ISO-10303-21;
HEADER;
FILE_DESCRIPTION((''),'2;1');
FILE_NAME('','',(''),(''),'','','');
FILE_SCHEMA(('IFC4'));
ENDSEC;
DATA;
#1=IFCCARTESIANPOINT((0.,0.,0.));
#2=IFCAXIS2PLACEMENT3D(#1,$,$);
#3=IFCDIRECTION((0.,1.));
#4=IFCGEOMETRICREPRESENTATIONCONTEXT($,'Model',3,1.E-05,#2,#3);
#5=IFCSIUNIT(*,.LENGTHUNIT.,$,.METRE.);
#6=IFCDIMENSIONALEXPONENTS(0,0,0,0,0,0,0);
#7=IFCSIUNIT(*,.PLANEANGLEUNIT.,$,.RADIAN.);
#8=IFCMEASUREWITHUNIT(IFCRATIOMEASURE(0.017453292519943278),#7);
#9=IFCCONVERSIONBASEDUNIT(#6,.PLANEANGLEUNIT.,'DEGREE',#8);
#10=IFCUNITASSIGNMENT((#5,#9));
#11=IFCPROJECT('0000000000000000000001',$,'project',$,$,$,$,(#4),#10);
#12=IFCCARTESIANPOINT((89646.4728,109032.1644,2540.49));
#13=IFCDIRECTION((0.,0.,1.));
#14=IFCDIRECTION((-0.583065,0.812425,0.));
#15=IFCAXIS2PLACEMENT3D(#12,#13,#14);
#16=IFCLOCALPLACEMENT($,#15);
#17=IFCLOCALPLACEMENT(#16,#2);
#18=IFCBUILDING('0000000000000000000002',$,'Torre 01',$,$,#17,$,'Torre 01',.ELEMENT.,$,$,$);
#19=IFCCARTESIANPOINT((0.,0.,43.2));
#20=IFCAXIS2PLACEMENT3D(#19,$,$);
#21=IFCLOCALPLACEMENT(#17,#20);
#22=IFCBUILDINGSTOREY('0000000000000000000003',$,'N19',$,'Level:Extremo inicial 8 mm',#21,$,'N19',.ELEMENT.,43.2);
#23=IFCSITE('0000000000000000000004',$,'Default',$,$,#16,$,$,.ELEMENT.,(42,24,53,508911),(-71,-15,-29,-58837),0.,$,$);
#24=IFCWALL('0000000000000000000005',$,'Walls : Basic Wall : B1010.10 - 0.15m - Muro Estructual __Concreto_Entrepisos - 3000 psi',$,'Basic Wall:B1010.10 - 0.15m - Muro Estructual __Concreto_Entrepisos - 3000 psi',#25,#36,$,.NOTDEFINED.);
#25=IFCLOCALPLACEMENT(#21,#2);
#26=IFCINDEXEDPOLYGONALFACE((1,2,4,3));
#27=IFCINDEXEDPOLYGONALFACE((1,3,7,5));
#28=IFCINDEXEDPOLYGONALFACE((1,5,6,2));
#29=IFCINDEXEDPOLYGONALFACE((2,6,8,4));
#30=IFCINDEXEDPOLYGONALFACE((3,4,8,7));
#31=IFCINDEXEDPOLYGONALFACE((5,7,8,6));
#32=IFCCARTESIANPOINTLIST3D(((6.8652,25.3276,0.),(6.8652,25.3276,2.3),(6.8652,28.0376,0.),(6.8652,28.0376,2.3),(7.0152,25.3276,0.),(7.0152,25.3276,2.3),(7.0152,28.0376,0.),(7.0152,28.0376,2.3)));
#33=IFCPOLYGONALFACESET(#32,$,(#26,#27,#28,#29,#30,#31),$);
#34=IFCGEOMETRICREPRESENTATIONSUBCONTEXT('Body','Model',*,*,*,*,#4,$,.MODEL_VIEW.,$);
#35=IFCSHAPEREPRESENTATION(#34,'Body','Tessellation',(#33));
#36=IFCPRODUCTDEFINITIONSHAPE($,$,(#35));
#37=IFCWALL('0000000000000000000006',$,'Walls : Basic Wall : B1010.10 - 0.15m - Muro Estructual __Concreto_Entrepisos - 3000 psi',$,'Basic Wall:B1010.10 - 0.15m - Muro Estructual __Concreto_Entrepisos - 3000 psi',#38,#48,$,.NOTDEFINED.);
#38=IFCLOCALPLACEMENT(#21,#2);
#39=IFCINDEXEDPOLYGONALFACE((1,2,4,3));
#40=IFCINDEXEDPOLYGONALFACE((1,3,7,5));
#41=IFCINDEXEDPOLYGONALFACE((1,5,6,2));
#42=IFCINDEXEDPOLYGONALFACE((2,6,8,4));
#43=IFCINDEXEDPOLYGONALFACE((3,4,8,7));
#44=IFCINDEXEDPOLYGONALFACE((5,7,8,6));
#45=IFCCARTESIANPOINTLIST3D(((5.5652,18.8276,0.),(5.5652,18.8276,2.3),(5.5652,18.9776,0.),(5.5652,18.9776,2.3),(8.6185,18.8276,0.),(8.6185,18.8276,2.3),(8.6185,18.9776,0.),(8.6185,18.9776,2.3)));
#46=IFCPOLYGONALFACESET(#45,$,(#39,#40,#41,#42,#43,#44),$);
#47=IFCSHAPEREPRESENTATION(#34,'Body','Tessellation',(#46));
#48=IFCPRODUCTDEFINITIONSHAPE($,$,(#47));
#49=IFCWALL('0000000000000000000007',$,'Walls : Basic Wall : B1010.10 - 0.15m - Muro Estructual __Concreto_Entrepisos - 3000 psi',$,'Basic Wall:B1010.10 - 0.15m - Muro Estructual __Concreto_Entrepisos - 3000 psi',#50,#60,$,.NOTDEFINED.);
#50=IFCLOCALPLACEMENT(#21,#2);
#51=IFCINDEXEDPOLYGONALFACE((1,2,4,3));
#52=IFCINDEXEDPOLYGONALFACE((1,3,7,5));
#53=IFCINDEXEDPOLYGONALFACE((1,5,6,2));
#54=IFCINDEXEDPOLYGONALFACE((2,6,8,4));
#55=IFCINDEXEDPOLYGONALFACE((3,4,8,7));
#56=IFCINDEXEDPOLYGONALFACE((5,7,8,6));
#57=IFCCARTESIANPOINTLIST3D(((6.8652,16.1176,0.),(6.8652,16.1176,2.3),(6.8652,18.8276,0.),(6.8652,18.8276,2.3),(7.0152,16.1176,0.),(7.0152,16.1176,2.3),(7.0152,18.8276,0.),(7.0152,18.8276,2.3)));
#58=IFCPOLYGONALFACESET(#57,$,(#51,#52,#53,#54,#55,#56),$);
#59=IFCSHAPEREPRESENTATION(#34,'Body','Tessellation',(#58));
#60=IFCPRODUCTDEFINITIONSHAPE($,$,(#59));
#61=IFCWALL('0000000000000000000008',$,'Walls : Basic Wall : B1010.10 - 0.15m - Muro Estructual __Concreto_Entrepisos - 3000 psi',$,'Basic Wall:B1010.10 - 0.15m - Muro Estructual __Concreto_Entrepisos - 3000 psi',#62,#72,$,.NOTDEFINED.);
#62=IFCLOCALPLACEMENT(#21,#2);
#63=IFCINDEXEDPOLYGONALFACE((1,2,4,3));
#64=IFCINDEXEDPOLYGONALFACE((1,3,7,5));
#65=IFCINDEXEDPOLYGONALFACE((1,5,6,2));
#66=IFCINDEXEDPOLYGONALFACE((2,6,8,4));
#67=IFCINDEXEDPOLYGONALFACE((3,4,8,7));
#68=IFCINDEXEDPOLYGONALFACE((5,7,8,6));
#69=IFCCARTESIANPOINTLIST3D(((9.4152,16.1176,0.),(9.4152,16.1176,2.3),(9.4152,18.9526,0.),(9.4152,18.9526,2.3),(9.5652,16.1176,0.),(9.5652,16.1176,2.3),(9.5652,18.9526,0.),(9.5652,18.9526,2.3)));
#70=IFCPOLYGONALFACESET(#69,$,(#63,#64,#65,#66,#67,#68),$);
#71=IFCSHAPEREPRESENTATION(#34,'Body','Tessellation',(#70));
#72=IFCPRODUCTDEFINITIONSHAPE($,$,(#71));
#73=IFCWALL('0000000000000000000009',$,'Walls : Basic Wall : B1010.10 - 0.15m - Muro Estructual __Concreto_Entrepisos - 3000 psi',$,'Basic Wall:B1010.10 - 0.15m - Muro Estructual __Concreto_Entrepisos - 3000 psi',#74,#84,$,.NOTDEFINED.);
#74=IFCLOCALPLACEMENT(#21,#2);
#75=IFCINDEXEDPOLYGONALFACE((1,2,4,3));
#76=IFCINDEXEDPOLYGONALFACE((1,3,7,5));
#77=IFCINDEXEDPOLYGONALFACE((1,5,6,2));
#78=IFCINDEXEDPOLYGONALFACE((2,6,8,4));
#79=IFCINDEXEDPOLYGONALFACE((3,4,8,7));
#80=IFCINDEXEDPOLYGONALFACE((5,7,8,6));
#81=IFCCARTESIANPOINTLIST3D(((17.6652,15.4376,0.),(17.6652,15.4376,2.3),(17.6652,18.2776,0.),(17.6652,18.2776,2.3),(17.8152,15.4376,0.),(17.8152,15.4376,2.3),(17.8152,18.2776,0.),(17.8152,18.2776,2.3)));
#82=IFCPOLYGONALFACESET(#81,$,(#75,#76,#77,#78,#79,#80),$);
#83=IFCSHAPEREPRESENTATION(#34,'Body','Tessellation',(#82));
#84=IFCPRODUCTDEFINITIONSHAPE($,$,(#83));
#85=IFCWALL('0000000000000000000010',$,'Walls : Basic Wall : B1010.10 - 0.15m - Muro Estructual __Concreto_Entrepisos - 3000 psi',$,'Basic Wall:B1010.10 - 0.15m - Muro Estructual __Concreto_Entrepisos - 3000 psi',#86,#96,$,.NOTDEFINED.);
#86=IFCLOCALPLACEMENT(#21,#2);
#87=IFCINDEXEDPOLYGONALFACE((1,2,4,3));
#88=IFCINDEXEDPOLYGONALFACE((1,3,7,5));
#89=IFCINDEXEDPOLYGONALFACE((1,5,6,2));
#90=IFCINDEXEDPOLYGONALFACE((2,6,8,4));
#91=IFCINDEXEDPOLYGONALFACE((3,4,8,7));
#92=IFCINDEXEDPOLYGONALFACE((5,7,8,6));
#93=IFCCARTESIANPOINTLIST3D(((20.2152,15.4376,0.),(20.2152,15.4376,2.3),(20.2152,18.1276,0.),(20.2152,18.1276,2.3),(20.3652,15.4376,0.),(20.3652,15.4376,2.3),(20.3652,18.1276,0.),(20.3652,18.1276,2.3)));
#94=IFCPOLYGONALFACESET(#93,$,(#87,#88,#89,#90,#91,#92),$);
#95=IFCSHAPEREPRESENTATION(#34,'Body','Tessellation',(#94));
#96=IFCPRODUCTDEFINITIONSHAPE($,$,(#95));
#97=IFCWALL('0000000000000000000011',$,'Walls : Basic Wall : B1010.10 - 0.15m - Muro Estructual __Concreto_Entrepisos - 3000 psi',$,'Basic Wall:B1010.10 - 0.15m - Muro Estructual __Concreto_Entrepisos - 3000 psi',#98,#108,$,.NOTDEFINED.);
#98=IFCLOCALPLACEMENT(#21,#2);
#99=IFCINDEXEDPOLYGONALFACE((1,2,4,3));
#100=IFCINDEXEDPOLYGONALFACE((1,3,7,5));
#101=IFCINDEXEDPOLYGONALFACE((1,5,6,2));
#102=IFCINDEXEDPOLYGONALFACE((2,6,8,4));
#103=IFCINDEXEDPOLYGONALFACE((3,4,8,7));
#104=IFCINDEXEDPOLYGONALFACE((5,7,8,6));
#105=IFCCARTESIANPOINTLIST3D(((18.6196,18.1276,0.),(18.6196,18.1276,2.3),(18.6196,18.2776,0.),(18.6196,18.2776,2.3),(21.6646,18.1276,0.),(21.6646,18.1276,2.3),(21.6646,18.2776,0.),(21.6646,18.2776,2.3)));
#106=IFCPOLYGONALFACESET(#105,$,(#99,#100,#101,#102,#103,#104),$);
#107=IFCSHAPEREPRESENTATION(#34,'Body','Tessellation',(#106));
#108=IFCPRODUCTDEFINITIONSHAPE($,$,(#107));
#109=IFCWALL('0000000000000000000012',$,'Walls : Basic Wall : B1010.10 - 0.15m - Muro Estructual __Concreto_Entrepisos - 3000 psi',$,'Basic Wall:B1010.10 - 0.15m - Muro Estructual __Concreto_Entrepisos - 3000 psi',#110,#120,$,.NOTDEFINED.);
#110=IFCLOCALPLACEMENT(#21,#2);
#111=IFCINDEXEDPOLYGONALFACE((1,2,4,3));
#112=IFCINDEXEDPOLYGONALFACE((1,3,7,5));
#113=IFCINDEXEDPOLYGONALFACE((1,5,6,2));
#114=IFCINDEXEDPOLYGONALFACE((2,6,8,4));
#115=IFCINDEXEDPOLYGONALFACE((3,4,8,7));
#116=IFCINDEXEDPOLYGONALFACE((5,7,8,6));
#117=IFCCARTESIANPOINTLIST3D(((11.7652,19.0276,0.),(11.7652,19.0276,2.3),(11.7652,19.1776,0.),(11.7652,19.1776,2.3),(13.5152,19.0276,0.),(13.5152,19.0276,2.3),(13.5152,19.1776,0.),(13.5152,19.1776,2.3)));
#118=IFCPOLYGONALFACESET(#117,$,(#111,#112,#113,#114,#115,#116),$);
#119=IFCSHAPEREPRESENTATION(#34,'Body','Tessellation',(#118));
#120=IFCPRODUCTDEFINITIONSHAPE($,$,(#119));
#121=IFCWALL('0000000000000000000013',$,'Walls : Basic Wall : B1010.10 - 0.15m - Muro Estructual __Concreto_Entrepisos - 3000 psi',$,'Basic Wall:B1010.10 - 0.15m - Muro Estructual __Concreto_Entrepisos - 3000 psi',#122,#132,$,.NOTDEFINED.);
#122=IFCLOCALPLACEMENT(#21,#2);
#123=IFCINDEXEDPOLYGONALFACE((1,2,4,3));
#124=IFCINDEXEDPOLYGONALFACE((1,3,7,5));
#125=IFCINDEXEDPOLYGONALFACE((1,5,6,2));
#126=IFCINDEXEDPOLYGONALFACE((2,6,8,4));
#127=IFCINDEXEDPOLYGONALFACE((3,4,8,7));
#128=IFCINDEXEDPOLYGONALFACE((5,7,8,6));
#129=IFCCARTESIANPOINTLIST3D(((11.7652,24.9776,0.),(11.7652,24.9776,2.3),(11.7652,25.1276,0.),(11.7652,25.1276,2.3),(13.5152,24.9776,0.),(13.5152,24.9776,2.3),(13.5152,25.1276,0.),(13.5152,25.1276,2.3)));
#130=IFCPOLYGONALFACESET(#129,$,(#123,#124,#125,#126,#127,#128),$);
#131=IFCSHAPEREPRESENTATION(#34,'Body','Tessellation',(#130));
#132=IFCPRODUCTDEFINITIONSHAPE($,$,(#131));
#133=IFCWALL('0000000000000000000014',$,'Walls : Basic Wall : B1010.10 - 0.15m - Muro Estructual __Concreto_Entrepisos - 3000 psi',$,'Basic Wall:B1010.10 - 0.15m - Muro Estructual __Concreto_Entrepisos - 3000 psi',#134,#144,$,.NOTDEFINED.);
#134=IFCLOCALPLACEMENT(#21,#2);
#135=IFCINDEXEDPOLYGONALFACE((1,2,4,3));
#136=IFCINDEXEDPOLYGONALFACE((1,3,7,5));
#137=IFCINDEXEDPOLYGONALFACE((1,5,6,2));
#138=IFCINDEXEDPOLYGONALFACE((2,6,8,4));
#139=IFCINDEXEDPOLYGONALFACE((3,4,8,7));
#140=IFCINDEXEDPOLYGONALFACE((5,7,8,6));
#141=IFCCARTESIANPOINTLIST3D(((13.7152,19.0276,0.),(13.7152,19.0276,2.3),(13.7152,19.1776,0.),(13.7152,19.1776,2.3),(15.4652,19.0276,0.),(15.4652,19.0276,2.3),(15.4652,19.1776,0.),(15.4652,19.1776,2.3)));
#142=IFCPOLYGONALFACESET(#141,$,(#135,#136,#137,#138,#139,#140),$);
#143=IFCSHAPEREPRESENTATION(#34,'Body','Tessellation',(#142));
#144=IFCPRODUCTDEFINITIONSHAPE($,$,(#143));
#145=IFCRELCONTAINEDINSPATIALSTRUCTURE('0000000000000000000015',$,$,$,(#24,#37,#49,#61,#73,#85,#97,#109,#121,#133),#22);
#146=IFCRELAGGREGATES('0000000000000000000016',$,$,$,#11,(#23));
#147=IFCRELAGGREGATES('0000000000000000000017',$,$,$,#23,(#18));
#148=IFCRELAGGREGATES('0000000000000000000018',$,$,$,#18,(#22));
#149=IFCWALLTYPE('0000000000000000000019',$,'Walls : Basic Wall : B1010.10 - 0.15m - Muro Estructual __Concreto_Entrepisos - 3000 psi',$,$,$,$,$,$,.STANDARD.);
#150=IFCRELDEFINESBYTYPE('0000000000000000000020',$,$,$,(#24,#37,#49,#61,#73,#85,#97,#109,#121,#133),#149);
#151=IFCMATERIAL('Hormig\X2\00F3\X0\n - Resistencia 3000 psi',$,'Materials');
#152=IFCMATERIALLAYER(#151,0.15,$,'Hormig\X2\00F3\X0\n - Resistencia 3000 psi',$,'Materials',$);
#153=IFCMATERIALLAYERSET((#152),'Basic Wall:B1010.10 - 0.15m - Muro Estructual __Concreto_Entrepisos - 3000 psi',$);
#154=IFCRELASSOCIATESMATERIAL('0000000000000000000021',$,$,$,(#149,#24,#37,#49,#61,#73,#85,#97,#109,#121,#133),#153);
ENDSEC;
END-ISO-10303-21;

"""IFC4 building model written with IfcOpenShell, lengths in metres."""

from ifc_helpers import new_model, entity, si_unit, converted_unit, direction, frame, frame_2d, origin, place, context, subcontext, project, spatial, rectangle, extrude, material, layer, layer_set, layer_usage, type_object, element, save


model = new_model("IFC4")

# Units and contexts
model_context = context("Model", 3, precision=1e-05, world=origin(), true_north=direction((0.0, 1.0)))
body_context = subcontext(model_context, "Body", "Model", "MODEL_VIEW")
ifc_project = project(units=[si_unit("LENGTHUNIT", "METRE"), converted_unit("PLANEANGLEUNIT", "DEGREE", entity("IfcRatioMeasure", 0.017453292519943278), si_unit("PLANEANGLEUNIT", "RADIAN"), dimensions=[0, 0, 0, 0, 0, 0, 0])], contexts=[model_context])

# Site, building, storey
site_placement = place(None, frame((89646.4728, 109032.1644, 2540.49), z_axis=(0.0, 0.0, 1.0), x_axis=(-0.583065, 0.812425, 0.0)))
site = spatial("IfcSite", under=ifc_project, at=site_placement, Name="Default", CompositionType="ELEMENT", RefLatitude=(42, 24, 53, 508911), RefLongitude=(-71, -15, -29, -58837), RefElevation=0.0)
building_placement = place(site_placement, origin())
building = spatial("IfcBuilding", under=site, at=building_placement, Name="Torre 01", LongName="Torre 01", CompositionType="ELEMENT")
storey_placement = place(building_placement, frame((0.0, 0.0, 43.2)))
storey = spatial("IfcBuildingStorey", under=building, at=storey_placement, Name="N19", ObjectType="Level:Extremo inicial 8 mm", LongName="N19", CompositionType="ELEMENT", Elevation=43.2)

# Walls
ifc_material = material(Name="Hormigón - Resistencia 3000 psi", Category="Materials")
ifc_layer_1 = layer(ifc_material, 0.15, Name="Hormigón - Resistencia 3000 psi", Category="Materials")
ifc_layer_set_1 = layer_set([ifc_layer_1], Name="Basic Wall:B1010.10 - 0.15m - Muro Estructual __Concreto_Entrepisos - 3000 psi")
wall_type_1 = type_object("IfcWallType", Name="Walls : Basic Wall : B1010.10 - 0.15m - Muro Estructual __Concreto_Entrepisos - 3000 psi", PredefinedType="STANDARD", material=ifc_layer_set_1)
ifc_layer_usage_1 = layer_usage(ifc_layer_set_1, "AXIS2", "NEGATIVE", 0.075)
wall_1_placement = place(storey_placement, frame((6.9402, 25.3276, 0.0), z_axis=(0.0, 0.0, 1.0), x_axis=(0.0, 1.0, 0.0)))
element("IfcWall", 1, at=wall_1_placement, inside=storey, type_object=wall_type_1, material=ifc_layer_usage_1, Name="Walls : Basic Wall : B1010.10 - 0.15m - Muro Estructual __Concreto_Entrepisos - 3000 psi", ObjectType="Basic Wall:B1010.10 - 0.15m - Muro Estructual __Concreto_Entrepisos - 3000 psi", PredefinedType="NOTDEFINED", context=body_context, shape_type="SweptSolid", body=[
    extrude(rectangle(XDim=2.71, YDim=0.15, at=frame_2d((1.355, 0.0), x_axis=(-1.0, 0.0))), origin(), (0.0, 0.0, 1.0), 2.3),
])
ifc_layer_usage_2 = layer_usage(ifc_layer_set_1, "AXIS2", "POSITIVE", -0.075)
wall_2_placement = place(storey_placement, frame((5.5652, 18.9026, 0.0)))
element("IfcWall", 2, at=wall_2_placement, inside=storey, type_object=wall_type_1, material=ifc_layer_usage_2, Name="Walls : Basic Wall : B1010.10 - 0.15m - Muro Estructual __Concreto_Entrepisos - 3000 psi", ObjectType="Basic Wall:B1010.10 - 0.15m - Muro Estructual __Concreto_Entrepisos - 3000 psi", PredefinedType="NOTDEFINED", context=body_context, shape_type="SweptSolid", body=[
    extrude(rectangle(XDim=3.0533, YDim=0.15, at=frame_2d((1.5267, 0.0), x_axis=(-1.0, 0.0))), origin(), (0.0, 0.0, 1.0), 2.3),
])
ifc_layer_usage_3 = layer_usage(ifc_layer_set_1, "AXIS2", "NEGATIVE", 0.075)
wall_3_placement = place(storey_placement, frame((6.9402, 18.8276, 0.0), z_axis=(0.0, 0.0, 1.0), x_axis=(0.0, -1.0, 0.0)))
element("IfcWall", 3, at=wall_3_placement, inside=storey, type_object=wall_type_1, material=ifc_layer_usage_3, Name="Walls : Basic Wall : B1010.10 - 0.15m - Muro Estructual __Concreto_Entrepisos - 3000 psi", ObjectType="Basic Wall:B1010.10 - 0.15m - Muro Estructual __Concreto_Entrepisos - 3000 psi", PredefinedType="NOTDEFINED", context=body_context, shape_type="SweptSolid", body=[
    extrude(rectangle(XDim=2.71, YDim=0.15, at=frame_2d((1.355, 0.0), x_axis=(-1.0, 0.0))), origin(), (0.0, 0.0, 1.0), 2.3),
])
ifc_layer_usage_4 = layer_usage(ifc_layer_set_1, "AXIS2", "NEGATIVE", 0.075)
wall_4_placement = place(storey_placement, frame((9.4902, 18.9526, 0.0), z_axis=(0.0, 0.0, 1.0), x_axis=(0.0, -1.0, 0.0)))
element("IfcWall", 4, at=wall_4_placement, inside=storey, type_object=wall_type_1, material=ifc_layer_usage_4, Name="Walls : Basic Wall : B1010.10 - 0.15m - Muro Estructual __Concreto_Entrepisos - 3000 psi", ObjectType="Basic Wall:B1010.10 - 0.15m - Muro Estructual __Concreto_Entrepisos - 3000 psi", PredefinedType="NOTDEFINED", context=body_context, shape_type="SweptSolid", body=[
    extrude(rectangle(XDim=2.835, YDim=0.15, at=frame_2d((1.4175, 0.0), x_axis=(-1.0, 0.0))), origin(), (0.0, 0.0, 1.0), 2.3),
])
ifc_layer_usage_5 = layer_usage(ifc_layer_set_1, "AXIS2", "NEGATIVE", 0.075)
wall_5_placement = place(storey_placement, frame((17.7402, 18.2776, 0.0), z_axis=(0.0, 0.0, 1.0), x_axis=(0.0, -1.0, 0.0)))
element("IfcWall", 5, at=wall_5_placement, inside=storey, type_object=wall_type_1, material=ifc_layer_usage_5, Name="Walls : Basic Wall : B1010.10 - 0.15m - Muro Estructual __Concreto_Entrepisos - 3000 psi", ObjectType="Basic Wall:B1010.10 - 0.15m - Muro Estructual __Concreto_Entrepisos - 3000 psi", PredefinedType="NOTDEFINED", context=body_context, shape_type="SweptSolid", body=[
    extrude(rectangle(XDim=2.84, YDim=0.15, at=frame_2d((1.42, 0.0), x_axis=(-1.0, 0.0))), origin(), (0.0, 0.0, 1.0), 2.3),
])
ifc_layer_usage_6 = layer_usage(ifc_layer_set_1, "AXIS2", "NEGATIVE", 0.075)
wall_6_placement = place(storey_placement, frame((20.2902, 15.4376, 0.0), z_axis=(0.0, 0.0, 1.0), x_axis=(0.0, 1.0, 0.0)))
element("IfcWall", 6, at=wall_6_placement, inside=storey, type_object=wall_type_1, material=ifc_layer_usage_6, Name="Walls : Basic Wall : B1010.10 - 0.15m - Muro Estructual __Concreto_Entrepisos - 3000 psi", ObjectType="Basic Wall:B1010.10 - 0.15m - Muro Estructual __Concreto_Entrepisos - 3000 psi", PredefinedType="NOTDEFINED", context=body_context, shape_type="SweptSolid", body=[
    extrude(rectangle(XDim=2.69, YDim=0.15, at=frame_2d((1.345, 0.0), x_axis=(-1.0, 0.0))), origin(), (0.0, 0.0, 1.0), 2.3),
])
ifc_layer_usage_7 = layer_usage(ifc_layer_set_1, "AXIS2", "NEGATIVE", 0.075)
wall_7_placement = place(storey_placement, frame((18.6196, 18.2026, 0.0)))
element("IfcWall", 7, at=wall_7_placement, inside=storey, type_object=wall_type_1, material=ifc_layer_usage_7, Name="Walls : Basic Wall : B1010.10 - 0.15m - Muro Estructual __Concreto_Entrepisos - 3000 psi", ObjectType="Basic Wall:B1010.10 - 0.15m - Muro Estructual __Concreto_Entrepisos - 3000 psi", PredefinedType="NOTDEFINED", context=body_context, shape_type="SweptSolid", body=[
    extrude(rectangle(XDim=3.045, YDim=0.15, at=frame_2d((1.5225, 0.0), x_axis=(-1.0, 0.0))), origin(), (0.0, 0.0, 1.0), 2.3),
])
ifc_layer_usage_8 = layer_usage(ifc_layer_set_1, "AXIS2", "NEGATIVE", 0.075)
wall_8_placement = place(storey_placement, frame((11.7652, 19.1026, 0.0)))
element("IfcWall", 8, at=wall_8_placement, inside=storey, type_object=wall_type_1, material=ifc_layer_usage_8, Name="Walls : Basic Wall : B1010.10 - 0.15m - Muro Estructual __Concreto_Entrepisos - 3000 psi", ObjectType="Basic Wall:B1010.10 - 0.15m - Muro Estructual __Concreto_Entrepisos - 3000 psi", PredefinedType="NOTDEFINED", context=body_context, shape_type="SweptSolid", body=[
    extrude(rectangle(XDim=1.75, YDim=0.15, at=frame_2d((0.875, 0.0), x_axis=(-1.0, 0.0))), origin(), (0.0, 0.0, 1.0), 2.3),
])
ifc_layer_usage_9 = layer_usage(ifc_layer_set_1, "AXIS2", "POSITIVE", -0.075)
wall_9_placement = place(storey_placement, frame((11.7652, 25.0526, 0.0)))
element("IfcWall", 9, at=wall_9_placement, inside=storey, type_object=wall_type_1, material=ifc_layer_usage_9, Name="Walls : Basic Wall : B1010.10 - 0.15m - Muro Estructual __Concreto_Entrepisos - 3000 psi", ObjectType="Basic Wall:B1010.10 - 0.15m - Muro Estructual __Concreto_Entrepisos - 3000 psi", PredefinedType="NOTDEFINED", context=body_context, shape_type="SweptSolid", body=[
    extrude(rectangle(XDim=1.75, YDim=0.15, at=frame_2d((0.875, 0.0), x_axis=(-1.0, 0.0))), origin(), (0.0, 0.0, 1.0), 2.3),
])
ifc_layer_usage_10 = layer_usage(ifc_layer_set_1, "AXIS2", "NEGATIVE", 0.075)
wall_10_placement = place(storey_placement, frame((13.7152, 19.1026, 0.0)))
element("IfcWall", 10, at=wall_10_placement, inside=storey, type_object=wall_type_1, material=ifc_layer_usage_10, Name="Walls : Basic Wall : B1010.10 - 0.15m - Muro Estructual __Concreto_Entrepisos - 3000 psi", ObjectType="Basic Wall:B1010.10 - 0.15m - Muro Estructual __Concreto_Entrepisos - 3000 psi", PredefinedType="NOTDEFINED", context=body_context, shape_type="SweptSolid", body=[
    extrude(rectangle(XDim=1.75, YDim=0.15, at=frame_2d((0.875, 0.0), x_axis=(-1.0, 0.0))), origin(), (0.0, 0.0, 1.0), 2.3),
])

save(model, "model.ifc")
